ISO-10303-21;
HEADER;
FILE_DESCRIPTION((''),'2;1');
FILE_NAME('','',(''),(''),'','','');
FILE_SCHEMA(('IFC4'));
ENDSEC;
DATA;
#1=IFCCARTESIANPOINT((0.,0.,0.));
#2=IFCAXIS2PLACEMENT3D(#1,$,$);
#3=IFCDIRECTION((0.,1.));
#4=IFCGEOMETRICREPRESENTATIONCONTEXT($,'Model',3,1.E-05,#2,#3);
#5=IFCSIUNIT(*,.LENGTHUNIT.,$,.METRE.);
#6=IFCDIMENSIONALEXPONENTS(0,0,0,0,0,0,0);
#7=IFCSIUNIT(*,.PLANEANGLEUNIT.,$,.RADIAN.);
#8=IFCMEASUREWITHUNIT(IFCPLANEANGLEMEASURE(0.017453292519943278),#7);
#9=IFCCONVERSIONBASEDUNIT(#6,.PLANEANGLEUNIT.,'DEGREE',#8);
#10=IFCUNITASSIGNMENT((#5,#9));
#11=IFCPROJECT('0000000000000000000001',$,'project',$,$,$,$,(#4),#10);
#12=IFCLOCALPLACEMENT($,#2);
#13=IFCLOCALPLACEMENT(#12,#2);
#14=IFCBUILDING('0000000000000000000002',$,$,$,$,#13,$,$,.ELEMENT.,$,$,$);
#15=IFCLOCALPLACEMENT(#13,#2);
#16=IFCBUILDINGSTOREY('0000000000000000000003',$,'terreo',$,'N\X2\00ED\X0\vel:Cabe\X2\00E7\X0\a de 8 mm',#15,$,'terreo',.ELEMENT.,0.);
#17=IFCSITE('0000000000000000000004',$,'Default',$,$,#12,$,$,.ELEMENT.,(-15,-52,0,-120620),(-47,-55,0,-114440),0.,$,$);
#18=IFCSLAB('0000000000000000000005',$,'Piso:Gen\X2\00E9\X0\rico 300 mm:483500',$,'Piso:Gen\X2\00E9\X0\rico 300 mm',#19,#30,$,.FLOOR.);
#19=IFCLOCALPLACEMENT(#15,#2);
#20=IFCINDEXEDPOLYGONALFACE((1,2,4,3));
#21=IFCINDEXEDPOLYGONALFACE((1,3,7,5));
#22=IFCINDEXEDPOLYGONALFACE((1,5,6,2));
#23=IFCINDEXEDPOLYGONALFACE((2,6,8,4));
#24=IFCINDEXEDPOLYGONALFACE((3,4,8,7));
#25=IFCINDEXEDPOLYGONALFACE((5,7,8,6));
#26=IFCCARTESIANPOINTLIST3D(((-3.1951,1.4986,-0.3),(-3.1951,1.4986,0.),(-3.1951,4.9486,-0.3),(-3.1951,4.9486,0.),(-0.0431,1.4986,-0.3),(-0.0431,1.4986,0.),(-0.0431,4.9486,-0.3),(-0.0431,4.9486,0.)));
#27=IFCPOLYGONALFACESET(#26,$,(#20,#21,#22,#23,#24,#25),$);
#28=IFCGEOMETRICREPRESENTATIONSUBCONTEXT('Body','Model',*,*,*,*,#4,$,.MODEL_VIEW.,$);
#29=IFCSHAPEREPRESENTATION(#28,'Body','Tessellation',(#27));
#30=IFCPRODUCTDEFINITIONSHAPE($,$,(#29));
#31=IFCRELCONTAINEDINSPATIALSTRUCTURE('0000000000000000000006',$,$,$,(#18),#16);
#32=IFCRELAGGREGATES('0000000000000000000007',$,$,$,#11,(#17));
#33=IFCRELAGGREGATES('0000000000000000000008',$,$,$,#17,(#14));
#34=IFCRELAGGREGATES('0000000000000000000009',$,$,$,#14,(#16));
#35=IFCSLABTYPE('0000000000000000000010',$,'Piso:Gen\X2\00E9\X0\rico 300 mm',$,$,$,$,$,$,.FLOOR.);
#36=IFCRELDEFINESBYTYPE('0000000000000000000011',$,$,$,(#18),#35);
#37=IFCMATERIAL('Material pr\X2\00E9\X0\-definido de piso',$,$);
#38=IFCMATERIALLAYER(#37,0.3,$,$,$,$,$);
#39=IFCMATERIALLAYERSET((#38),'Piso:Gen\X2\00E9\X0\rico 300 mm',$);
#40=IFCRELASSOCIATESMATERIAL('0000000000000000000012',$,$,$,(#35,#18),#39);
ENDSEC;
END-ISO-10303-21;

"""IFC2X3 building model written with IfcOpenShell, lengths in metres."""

from ifc_helpers import new_model, entity, si_unit, converted_unit, direction, frame, frame_2d, origin, place, context, subcontext, project, spatial, rectangle, extrude, material, layer, layer_set, layer_usage, type_object, element, save


model = new_model("IFC2X3")

# Units and contexts
model_context = context("Model", 3, precision=1e-05, world=origin(), true_north=direction((0.0, 1.0)))
body_context = subcontext(model_context, "Body", "Model", "MODEL_VIEW")
ifc_project = project(units=[si_unit("LENGTHUNIT", "METRE"), converted_unit("PLANEANGLEUNIT", "DEGREE", entity("IfcPlaneAngleMeasure", 0.017453292519943278), si_unit("PLANEANGLEUNIT", "RADIAN"), dimensions=[0, 0, 0, 0, 0, 0, 0])], contexts=[model_context])

# Site, building, storey
site_placement = place(None, origin())
site = spatial("IfcSite", under=ifc_project, at=site_placement, Name="Default", CompositionType="ELEMENT", RefLatitude=(-15, -52, 0, -120620), RefLongitude=(-47, -55, 0, -114440), RefElevation=0.0)
building_placement = place(site_placement, origin())
building = spatial("IfcBuilding", under=site, at=building_placement, CompositionType="ELEMENT")
storey_placement = place(building_placement, origin())
storey = spatial("IfcBuildingStorey", under=building, at=storey_placement, Name="terreo", ObjectType="Nível:Cabeça de 8 mm", LongName="terreo", CompositionType="ELEMENT", Elevation=0.0)

# Slab
ifc_material_1 = material(Name="Material pré-definido de piso")
ifc_layer = layer(ifc_material_1, 0.3)
ifc_layer_set = layer_set([ifc_layer], Name="Piso:Genérico 300 mm")
slab_type = type_object("IfcSlabType", Name="Piso:Genérico 300 mm", PredefinedType="FLOOR", material=ifc_layer_set)
ifc_layer_usage_1 = layer_usage(ifc_layer_set, "AXIS3", "POSITIVE", 0.0)
slab_1_placement = place(storey_placement, origin())
element("IfcSlab", 1, at=slab_1_placement, inside=storey, type_object=slab_type, material=ifc_layer_usage_1, Name="Piso:Genérico 300 mm:483500", ObjectType="Piso:Genérico 300 mm", PredefinedType="FLOOR", context=body_context, shape_type="SweptSolid", body=[
    extrude(rectangle(XDim=3.45, YDim=3.152, at=frame_2d((0.0, 0.0), x_axis=(1.0, 0.0))), frame((-1.6191, 3.2236, 0.0), z_axis=(0.0, 0.0, -1.0), x_axis=(0.0, 1.0, 0.0)), (0.0, 0.0, 1.0), 0.3),
])

save(model, "model.ifc")
